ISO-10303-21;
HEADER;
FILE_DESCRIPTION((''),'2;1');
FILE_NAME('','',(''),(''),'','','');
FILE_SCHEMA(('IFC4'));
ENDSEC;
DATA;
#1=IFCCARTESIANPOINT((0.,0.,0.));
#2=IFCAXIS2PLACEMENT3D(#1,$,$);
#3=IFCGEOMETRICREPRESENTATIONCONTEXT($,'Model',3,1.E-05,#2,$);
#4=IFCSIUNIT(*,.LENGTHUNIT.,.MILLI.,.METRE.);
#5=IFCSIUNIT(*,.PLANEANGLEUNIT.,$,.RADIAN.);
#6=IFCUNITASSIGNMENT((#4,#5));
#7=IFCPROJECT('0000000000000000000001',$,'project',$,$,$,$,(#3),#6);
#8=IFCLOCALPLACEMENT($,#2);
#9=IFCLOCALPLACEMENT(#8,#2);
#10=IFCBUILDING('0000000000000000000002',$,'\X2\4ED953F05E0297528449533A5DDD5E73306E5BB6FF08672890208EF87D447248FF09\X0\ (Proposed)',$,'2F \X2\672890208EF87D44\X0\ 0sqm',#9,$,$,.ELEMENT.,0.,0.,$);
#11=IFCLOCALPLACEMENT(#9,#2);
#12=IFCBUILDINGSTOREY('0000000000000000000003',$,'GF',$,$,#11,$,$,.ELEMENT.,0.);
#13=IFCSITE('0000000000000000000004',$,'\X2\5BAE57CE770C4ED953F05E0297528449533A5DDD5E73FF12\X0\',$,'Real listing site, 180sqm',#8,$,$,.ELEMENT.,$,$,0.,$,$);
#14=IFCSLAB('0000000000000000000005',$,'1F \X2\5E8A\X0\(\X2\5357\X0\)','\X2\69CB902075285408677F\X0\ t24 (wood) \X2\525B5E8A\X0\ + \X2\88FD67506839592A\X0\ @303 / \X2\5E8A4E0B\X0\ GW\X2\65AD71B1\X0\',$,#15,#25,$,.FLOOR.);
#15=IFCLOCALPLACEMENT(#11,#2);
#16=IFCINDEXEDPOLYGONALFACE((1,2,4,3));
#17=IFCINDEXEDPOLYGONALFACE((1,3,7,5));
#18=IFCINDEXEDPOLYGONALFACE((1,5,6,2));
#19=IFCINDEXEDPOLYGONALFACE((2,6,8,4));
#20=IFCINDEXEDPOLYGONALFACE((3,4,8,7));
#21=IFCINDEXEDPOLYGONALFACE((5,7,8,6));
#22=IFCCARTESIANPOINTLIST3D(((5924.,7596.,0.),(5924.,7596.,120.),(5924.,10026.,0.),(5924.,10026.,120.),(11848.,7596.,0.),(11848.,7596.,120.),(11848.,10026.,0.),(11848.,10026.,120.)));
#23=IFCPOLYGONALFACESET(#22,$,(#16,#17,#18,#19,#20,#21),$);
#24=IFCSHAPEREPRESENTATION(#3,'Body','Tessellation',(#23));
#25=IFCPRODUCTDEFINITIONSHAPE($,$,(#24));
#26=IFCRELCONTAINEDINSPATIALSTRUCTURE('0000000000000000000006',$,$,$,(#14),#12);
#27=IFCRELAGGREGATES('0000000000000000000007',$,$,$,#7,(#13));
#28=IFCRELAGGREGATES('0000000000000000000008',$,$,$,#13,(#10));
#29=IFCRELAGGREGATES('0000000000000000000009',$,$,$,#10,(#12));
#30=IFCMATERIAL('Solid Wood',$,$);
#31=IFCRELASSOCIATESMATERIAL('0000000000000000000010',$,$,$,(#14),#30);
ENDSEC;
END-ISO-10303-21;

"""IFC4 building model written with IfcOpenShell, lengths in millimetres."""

from ifc_helpers import new_model, si_unit, frame, frame_2d, origin, place, context, project, spatial, rectangle, extrude, material, element, save


model = new_model("IFC4")

# Units and contexts
model_context = context("Model", 3, precision=1e-05, world=origin())
ifc_project = project(units=[si_unit("LENGTHUNIT", "METRE", prefix="MILLI"), si_unit("PLANEANGLEUNIT", "RADIAN")], contexts=[model_context])

# Site, building, storey
site_placement = place(None, origin())
site = spatial("IfcSite", under=ifc_project, at=site_placement, Name="宮城県仙台市青葉区川平２", ObjectType="Real listing site, 180sqm", CompositionType="ELEMENT", RefElevation=0.0)
building_placement = place(site_placement, origin())
building = spatial("IfcBuilding", under=site, at=building_placement, Name="仙台市青葉区川平の家（木造軸組版） (Proposed)", ObjectType="2F 木造軸組 0sqm", CompositionType="ELEMENT", ElevationOfRefHeight=0.0, ElevationOfTerrain=0.0)
storey_placement = place(building_placement, origin())
storey = spatial("IfcBuildingStorey", under=building, at=storey_placement, Name="GF", CompositionType="ELEMENT", Elevation=0.0)

# Slab
ifc_material_1 = material(Name="Solid Wood")
slab_1_placement = place(storey_placement, frame((2962.0, 3798.0, 0.0)))
element("IfcSlab", 1, at=slab_1_placement, inside=storey, material=ifc_material_1, Name="1F 床(南)", Description="構造用合板 t24 (wood) 剛床 + 製材根太 @303 / 床下 GW断熱", PredefinedType="FLOOR", context=model_context, shape_type="SweptSolid", body=[
    extrude(rectangle(XDim=5924.0, YDim=2430.0, at=frame_2d((2962.0, 1215.0))), frame((2962.0, 3798.0, 0.0)), (0.0, 0.0, 1.0), 120.0),
])

save(model, "model.ifc")
